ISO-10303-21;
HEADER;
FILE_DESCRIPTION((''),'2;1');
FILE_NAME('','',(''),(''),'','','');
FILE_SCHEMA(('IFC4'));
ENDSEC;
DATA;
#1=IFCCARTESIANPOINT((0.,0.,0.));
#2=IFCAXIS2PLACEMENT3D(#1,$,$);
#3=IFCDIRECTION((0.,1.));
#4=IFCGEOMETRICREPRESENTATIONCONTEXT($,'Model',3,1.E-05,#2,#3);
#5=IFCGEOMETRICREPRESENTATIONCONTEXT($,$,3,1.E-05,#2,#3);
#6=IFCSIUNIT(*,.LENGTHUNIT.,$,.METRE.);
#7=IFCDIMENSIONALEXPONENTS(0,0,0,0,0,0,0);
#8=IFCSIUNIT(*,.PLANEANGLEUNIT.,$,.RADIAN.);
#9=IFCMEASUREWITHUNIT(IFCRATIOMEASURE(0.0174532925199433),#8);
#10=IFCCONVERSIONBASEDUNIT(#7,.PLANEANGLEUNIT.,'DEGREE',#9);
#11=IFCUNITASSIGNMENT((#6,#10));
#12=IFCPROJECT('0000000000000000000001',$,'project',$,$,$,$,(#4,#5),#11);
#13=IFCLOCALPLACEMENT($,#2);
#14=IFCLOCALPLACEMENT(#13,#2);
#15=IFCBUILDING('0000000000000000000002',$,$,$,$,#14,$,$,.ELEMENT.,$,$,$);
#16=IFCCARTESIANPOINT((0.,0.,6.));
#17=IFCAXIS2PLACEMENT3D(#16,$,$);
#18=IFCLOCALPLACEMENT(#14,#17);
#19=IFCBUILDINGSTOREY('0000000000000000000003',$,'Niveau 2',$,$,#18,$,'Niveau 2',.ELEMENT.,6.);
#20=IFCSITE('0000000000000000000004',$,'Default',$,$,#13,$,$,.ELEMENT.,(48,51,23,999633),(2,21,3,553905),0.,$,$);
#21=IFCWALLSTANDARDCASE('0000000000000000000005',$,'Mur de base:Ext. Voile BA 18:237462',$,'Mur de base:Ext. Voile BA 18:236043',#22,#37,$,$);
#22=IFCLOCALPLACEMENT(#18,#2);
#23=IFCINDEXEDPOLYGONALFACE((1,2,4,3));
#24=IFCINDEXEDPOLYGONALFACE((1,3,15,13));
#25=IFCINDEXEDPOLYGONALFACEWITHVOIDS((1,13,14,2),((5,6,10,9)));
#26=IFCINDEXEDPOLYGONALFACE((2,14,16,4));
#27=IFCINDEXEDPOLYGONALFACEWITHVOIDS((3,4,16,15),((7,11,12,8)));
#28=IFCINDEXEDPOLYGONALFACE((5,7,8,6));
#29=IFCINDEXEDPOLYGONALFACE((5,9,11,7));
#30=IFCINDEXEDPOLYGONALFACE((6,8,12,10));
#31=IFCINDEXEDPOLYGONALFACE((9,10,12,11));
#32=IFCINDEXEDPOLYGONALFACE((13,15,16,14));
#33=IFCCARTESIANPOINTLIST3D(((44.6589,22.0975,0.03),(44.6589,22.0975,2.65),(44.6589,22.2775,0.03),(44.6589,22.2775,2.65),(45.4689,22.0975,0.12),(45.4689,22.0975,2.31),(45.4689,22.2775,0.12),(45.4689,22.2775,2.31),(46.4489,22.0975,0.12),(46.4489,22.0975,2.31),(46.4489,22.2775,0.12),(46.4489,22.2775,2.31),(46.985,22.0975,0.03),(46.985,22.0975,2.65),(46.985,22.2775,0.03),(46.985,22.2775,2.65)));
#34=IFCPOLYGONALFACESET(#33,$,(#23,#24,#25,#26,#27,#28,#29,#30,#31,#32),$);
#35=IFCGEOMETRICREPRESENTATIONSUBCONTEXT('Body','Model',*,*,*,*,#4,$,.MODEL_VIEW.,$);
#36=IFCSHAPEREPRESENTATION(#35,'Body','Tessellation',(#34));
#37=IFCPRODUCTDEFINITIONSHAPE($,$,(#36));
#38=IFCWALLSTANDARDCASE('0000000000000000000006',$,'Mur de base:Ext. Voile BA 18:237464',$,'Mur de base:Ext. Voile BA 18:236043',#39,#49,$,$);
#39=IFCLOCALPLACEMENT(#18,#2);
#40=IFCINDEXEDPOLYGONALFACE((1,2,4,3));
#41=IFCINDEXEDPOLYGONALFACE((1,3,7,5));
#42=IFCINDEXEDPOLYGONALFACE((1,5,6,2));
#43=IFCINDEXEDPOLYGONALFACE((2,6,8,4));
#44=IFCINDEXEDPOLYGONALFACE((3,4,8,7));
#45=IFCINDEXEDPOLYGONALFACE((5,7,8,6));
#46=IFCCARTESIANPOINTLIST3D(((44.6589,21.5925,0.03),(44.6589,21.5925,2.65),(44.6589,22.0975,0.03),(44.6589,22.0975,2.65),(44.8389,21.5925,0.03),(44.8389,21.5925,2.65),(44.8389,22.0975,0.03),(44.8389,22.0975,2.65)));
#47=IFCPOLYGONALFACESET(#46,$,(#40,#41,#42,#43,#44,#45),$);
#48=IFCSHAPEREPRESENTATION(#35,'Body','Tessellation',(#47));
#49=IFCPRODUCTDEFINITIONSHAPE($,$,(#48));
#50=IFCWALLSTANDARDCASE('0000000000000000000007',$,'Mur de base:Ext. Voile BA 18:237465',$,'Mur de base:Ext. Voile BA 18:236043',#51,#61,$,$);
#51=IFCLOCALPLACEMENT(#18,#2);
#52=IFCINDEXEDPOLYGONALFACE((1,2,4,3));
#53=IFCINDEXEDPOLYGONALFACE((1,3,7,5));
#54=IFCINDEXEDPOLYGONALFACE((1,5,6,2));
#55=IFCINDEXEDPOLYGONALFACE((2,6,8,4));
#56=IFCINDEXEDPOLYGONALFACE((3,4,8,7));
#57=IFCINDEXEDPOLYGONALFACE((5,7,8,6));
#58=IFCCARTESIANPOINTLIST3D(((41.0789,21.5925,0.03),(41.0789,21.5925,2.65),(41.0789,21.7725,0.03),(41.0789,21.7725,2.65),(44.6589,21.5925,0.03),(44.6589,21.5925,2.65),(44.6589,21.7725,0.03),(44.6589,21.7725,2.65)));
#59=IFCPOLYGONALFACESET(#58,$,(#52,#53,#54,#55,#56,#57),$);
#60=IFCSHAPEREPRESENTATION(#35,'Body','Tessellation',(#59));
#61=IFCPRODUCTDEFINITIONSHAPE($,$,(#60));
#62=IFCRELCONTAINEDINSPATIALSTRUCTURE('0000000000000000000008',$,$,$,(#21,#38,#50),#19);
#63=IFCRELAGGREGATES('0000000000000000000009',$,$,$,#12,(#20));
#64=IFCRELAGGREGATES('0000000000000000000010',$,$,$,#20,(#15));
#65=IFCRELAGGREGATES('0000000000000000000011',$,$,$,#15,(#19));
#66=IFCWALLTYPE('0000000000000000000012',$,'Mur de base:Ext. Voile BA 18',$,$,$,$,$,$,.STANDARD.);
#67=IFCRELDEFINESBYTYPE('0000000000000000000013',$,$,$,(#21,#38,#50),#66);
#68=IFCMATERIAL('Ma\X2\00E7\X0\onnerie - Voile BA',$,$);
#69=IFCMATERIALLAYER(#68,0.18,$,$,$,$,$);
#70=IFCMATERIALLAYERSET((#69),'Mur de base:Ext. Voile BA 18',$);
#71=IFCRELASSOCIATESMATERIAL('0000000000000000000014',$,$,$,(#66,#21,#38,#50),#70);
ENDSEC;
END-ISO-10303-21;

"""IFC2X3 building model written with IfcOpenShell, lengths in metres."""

from ifc_helpers import new_model, entity, si_unit, converted_unit, direction, frame, frame_2d, origin, place, context, subcontext, project, spatial, rectangle, extrude, material, layer, layer_set, layer_usage, type_object, element, save


model = new_model("IFC2X3")

# Units and contexts
model_context = context("Model", 3, precision=1e-05, world=origin(), true_north=direction((0.0, 1.0)))
context_of_model = context(None, 3, precision=1e-05, world=origin(), true_north=direction((0.0, 1.0)))
body_context = subcontext(model_context, "Body", "Model", "MODEL_VIEW")
ifc_project = project(units=[si_unit("LENGTHUNIT", "METRE"), converted_unit("PLANEANGLEUNIT", "DEGREE", entity("IfcRatioMeasure", 0.0174532925199433), si_unit("PLANEANGLEUNIT", "RADIAN"), dimensions=[0, 0, 0, 0, 0, 0, 0])], contexts=[model_context, context_of_model])

# Site, building, storey
site_placement = place(None, origin())
site = spatial("IfcSite", under=ifc_project, at=site_placement, Name="Default", CompositionType="ELEMENT", RefLatitude=(48, 51, 23, 999633), RefLongitude=(2, 21, 3, 553905), RefElevation=0.0)
building_placement = place(site_placement, origin())
building = spatial("IfcBuilding", under=site, at=building_placement, CompositionType="ELEMENT")
storey_placement = place(building_placement, frame((0.0, 0.0, 6.0)))
storey = spatial("IfcBuildingStorey", under=building, at=storey_placement, Name="Niveau 2", LongName="Niveau 2", CompositionType="ELEMENT", Elevation=6.0)

# Shared definitions
ifc_material = material(Name="Maçonnerie - Voile BA")

# Shared definitions
ifc_layer_1 = layer(ifc_material, 0.18)
ifc_layer_set_1 = layer_set([ifc_layer_1], Name="Mur de base:Ext. Voile BA 18")
wall_type_1 = type_object("IfcWallType", Name="Mur de base:Ext. Voile BA 18", PredefinedType="STANDARD", material=ifc_layer_set_1)

# Wall, opening
ifc_layer_usage_1 = layer_usage(ifc_layer_set_1, "AXIS2", "POSITIVE", -0.09)
wall_1_placement = place(storey_placement, frame((46.985, 22.1875, 0.03), z_axis=(0.0, 0.0, 1.0), x_axis=(-1.0, 0.0, 0.0)))
wall_1 = element("IfcWallStandardCase", 1, at=wall_1_placement, inside=storey, type_object=wall_type_1, material=ifc_layer_usage_1, Name="Mur de base:Ext. Voile BA 18:237462", ObjectType="Mur de base:Ext. Voile BA 18:236043", context=body_context, shape_type="SweptSolid", body=[
    extrude(rectangle(XDim=2.3261, YDim=0.18, at=frame_2d((1.1631, 0.0), x_axis=(-1.0, 0.0))), origin(), (0.0, 0.0, 1.0), 2.62),
])
opening_1_placement = place(wall_1_placement, origin())
element("IfcOpeningElement", 2, at=opening_1_placement, cuts=wall_1, ObjectType="Opening", context=body_context, shape_type="SweptSolid", body=[
    extrude(rectangle(XDim=2.19, YDim=0.98, at=frame_2d((0.0, 0.0), x_axis=(1.0, 0.0))), frame((1.0261, -0.09, 1.185), z_axis=(0.0, 1.0, 0.0), x_axis=(0.0, 0.0, -1.0)), (0.0, 0.0, 1.0), 0.18),
])

# Walls
ifc_layer_usage_2 = layer_usage(ifc_layer_set_1, "AXIS2", "POSITIVE", -0.09)
wall_2_placement = place(storey_placement, frame((44.7489, 22.0975, 0.03), z_axis=(0.0, 0.0, 1.0), x_axis=(0.0, -1.0, 0.0)))
element("IfcWallStandardCase", 3, at=wall_2_placement, inside=storey, type_object=wall_type_1, material=ifc_layer_usage_2, Name="Mur de base:Ext. Voile BA 18:237464", ObjectType="Mur de base:Ext. Voile BA 18:236043", context=body_context, shape_type="SweptSolid", body=[
    extrude(rectangle(XDim=0.505, YDim=0.18, at=frame_2d((0.2525, 0.0), x_axis=(-1.0, 0.0))), origin(), (0.0, 0.0, 1.0), 2.62),
])
ifc_layer_usage_3 = layer_usage(ifc_layer_set_1, "AXIS2", "POSITIVE", -0.09)
wall_3_placement = place(storey_placement, frame((44.6589, 21.6825, 0.03), z_axis=(0.0, 0.0, 1.0), x_axis=(-1.0, 0.0, 0.0)))
element("IfcWallStandardCase", 4, at=wall_3_placement, inside=storey, type_object=wall_type_1, material=ifc_layer_usage_3, Name="Mur de base:Ext. Voile BA 18:237465", ObjectType="Mur de base:Ext. Voile BA 18:236043", context=body_context, shape_type="SweptSolid", body=[
    extrude(rectangle(XDim=3.58, YDim=0.18, at=frame_2d((1.79, 0.0), x_axis=(-1.0, 0.0))), origin(), (0.0, 0.0, 1.0), 2.62),
])

save(model, "model.ifc")
